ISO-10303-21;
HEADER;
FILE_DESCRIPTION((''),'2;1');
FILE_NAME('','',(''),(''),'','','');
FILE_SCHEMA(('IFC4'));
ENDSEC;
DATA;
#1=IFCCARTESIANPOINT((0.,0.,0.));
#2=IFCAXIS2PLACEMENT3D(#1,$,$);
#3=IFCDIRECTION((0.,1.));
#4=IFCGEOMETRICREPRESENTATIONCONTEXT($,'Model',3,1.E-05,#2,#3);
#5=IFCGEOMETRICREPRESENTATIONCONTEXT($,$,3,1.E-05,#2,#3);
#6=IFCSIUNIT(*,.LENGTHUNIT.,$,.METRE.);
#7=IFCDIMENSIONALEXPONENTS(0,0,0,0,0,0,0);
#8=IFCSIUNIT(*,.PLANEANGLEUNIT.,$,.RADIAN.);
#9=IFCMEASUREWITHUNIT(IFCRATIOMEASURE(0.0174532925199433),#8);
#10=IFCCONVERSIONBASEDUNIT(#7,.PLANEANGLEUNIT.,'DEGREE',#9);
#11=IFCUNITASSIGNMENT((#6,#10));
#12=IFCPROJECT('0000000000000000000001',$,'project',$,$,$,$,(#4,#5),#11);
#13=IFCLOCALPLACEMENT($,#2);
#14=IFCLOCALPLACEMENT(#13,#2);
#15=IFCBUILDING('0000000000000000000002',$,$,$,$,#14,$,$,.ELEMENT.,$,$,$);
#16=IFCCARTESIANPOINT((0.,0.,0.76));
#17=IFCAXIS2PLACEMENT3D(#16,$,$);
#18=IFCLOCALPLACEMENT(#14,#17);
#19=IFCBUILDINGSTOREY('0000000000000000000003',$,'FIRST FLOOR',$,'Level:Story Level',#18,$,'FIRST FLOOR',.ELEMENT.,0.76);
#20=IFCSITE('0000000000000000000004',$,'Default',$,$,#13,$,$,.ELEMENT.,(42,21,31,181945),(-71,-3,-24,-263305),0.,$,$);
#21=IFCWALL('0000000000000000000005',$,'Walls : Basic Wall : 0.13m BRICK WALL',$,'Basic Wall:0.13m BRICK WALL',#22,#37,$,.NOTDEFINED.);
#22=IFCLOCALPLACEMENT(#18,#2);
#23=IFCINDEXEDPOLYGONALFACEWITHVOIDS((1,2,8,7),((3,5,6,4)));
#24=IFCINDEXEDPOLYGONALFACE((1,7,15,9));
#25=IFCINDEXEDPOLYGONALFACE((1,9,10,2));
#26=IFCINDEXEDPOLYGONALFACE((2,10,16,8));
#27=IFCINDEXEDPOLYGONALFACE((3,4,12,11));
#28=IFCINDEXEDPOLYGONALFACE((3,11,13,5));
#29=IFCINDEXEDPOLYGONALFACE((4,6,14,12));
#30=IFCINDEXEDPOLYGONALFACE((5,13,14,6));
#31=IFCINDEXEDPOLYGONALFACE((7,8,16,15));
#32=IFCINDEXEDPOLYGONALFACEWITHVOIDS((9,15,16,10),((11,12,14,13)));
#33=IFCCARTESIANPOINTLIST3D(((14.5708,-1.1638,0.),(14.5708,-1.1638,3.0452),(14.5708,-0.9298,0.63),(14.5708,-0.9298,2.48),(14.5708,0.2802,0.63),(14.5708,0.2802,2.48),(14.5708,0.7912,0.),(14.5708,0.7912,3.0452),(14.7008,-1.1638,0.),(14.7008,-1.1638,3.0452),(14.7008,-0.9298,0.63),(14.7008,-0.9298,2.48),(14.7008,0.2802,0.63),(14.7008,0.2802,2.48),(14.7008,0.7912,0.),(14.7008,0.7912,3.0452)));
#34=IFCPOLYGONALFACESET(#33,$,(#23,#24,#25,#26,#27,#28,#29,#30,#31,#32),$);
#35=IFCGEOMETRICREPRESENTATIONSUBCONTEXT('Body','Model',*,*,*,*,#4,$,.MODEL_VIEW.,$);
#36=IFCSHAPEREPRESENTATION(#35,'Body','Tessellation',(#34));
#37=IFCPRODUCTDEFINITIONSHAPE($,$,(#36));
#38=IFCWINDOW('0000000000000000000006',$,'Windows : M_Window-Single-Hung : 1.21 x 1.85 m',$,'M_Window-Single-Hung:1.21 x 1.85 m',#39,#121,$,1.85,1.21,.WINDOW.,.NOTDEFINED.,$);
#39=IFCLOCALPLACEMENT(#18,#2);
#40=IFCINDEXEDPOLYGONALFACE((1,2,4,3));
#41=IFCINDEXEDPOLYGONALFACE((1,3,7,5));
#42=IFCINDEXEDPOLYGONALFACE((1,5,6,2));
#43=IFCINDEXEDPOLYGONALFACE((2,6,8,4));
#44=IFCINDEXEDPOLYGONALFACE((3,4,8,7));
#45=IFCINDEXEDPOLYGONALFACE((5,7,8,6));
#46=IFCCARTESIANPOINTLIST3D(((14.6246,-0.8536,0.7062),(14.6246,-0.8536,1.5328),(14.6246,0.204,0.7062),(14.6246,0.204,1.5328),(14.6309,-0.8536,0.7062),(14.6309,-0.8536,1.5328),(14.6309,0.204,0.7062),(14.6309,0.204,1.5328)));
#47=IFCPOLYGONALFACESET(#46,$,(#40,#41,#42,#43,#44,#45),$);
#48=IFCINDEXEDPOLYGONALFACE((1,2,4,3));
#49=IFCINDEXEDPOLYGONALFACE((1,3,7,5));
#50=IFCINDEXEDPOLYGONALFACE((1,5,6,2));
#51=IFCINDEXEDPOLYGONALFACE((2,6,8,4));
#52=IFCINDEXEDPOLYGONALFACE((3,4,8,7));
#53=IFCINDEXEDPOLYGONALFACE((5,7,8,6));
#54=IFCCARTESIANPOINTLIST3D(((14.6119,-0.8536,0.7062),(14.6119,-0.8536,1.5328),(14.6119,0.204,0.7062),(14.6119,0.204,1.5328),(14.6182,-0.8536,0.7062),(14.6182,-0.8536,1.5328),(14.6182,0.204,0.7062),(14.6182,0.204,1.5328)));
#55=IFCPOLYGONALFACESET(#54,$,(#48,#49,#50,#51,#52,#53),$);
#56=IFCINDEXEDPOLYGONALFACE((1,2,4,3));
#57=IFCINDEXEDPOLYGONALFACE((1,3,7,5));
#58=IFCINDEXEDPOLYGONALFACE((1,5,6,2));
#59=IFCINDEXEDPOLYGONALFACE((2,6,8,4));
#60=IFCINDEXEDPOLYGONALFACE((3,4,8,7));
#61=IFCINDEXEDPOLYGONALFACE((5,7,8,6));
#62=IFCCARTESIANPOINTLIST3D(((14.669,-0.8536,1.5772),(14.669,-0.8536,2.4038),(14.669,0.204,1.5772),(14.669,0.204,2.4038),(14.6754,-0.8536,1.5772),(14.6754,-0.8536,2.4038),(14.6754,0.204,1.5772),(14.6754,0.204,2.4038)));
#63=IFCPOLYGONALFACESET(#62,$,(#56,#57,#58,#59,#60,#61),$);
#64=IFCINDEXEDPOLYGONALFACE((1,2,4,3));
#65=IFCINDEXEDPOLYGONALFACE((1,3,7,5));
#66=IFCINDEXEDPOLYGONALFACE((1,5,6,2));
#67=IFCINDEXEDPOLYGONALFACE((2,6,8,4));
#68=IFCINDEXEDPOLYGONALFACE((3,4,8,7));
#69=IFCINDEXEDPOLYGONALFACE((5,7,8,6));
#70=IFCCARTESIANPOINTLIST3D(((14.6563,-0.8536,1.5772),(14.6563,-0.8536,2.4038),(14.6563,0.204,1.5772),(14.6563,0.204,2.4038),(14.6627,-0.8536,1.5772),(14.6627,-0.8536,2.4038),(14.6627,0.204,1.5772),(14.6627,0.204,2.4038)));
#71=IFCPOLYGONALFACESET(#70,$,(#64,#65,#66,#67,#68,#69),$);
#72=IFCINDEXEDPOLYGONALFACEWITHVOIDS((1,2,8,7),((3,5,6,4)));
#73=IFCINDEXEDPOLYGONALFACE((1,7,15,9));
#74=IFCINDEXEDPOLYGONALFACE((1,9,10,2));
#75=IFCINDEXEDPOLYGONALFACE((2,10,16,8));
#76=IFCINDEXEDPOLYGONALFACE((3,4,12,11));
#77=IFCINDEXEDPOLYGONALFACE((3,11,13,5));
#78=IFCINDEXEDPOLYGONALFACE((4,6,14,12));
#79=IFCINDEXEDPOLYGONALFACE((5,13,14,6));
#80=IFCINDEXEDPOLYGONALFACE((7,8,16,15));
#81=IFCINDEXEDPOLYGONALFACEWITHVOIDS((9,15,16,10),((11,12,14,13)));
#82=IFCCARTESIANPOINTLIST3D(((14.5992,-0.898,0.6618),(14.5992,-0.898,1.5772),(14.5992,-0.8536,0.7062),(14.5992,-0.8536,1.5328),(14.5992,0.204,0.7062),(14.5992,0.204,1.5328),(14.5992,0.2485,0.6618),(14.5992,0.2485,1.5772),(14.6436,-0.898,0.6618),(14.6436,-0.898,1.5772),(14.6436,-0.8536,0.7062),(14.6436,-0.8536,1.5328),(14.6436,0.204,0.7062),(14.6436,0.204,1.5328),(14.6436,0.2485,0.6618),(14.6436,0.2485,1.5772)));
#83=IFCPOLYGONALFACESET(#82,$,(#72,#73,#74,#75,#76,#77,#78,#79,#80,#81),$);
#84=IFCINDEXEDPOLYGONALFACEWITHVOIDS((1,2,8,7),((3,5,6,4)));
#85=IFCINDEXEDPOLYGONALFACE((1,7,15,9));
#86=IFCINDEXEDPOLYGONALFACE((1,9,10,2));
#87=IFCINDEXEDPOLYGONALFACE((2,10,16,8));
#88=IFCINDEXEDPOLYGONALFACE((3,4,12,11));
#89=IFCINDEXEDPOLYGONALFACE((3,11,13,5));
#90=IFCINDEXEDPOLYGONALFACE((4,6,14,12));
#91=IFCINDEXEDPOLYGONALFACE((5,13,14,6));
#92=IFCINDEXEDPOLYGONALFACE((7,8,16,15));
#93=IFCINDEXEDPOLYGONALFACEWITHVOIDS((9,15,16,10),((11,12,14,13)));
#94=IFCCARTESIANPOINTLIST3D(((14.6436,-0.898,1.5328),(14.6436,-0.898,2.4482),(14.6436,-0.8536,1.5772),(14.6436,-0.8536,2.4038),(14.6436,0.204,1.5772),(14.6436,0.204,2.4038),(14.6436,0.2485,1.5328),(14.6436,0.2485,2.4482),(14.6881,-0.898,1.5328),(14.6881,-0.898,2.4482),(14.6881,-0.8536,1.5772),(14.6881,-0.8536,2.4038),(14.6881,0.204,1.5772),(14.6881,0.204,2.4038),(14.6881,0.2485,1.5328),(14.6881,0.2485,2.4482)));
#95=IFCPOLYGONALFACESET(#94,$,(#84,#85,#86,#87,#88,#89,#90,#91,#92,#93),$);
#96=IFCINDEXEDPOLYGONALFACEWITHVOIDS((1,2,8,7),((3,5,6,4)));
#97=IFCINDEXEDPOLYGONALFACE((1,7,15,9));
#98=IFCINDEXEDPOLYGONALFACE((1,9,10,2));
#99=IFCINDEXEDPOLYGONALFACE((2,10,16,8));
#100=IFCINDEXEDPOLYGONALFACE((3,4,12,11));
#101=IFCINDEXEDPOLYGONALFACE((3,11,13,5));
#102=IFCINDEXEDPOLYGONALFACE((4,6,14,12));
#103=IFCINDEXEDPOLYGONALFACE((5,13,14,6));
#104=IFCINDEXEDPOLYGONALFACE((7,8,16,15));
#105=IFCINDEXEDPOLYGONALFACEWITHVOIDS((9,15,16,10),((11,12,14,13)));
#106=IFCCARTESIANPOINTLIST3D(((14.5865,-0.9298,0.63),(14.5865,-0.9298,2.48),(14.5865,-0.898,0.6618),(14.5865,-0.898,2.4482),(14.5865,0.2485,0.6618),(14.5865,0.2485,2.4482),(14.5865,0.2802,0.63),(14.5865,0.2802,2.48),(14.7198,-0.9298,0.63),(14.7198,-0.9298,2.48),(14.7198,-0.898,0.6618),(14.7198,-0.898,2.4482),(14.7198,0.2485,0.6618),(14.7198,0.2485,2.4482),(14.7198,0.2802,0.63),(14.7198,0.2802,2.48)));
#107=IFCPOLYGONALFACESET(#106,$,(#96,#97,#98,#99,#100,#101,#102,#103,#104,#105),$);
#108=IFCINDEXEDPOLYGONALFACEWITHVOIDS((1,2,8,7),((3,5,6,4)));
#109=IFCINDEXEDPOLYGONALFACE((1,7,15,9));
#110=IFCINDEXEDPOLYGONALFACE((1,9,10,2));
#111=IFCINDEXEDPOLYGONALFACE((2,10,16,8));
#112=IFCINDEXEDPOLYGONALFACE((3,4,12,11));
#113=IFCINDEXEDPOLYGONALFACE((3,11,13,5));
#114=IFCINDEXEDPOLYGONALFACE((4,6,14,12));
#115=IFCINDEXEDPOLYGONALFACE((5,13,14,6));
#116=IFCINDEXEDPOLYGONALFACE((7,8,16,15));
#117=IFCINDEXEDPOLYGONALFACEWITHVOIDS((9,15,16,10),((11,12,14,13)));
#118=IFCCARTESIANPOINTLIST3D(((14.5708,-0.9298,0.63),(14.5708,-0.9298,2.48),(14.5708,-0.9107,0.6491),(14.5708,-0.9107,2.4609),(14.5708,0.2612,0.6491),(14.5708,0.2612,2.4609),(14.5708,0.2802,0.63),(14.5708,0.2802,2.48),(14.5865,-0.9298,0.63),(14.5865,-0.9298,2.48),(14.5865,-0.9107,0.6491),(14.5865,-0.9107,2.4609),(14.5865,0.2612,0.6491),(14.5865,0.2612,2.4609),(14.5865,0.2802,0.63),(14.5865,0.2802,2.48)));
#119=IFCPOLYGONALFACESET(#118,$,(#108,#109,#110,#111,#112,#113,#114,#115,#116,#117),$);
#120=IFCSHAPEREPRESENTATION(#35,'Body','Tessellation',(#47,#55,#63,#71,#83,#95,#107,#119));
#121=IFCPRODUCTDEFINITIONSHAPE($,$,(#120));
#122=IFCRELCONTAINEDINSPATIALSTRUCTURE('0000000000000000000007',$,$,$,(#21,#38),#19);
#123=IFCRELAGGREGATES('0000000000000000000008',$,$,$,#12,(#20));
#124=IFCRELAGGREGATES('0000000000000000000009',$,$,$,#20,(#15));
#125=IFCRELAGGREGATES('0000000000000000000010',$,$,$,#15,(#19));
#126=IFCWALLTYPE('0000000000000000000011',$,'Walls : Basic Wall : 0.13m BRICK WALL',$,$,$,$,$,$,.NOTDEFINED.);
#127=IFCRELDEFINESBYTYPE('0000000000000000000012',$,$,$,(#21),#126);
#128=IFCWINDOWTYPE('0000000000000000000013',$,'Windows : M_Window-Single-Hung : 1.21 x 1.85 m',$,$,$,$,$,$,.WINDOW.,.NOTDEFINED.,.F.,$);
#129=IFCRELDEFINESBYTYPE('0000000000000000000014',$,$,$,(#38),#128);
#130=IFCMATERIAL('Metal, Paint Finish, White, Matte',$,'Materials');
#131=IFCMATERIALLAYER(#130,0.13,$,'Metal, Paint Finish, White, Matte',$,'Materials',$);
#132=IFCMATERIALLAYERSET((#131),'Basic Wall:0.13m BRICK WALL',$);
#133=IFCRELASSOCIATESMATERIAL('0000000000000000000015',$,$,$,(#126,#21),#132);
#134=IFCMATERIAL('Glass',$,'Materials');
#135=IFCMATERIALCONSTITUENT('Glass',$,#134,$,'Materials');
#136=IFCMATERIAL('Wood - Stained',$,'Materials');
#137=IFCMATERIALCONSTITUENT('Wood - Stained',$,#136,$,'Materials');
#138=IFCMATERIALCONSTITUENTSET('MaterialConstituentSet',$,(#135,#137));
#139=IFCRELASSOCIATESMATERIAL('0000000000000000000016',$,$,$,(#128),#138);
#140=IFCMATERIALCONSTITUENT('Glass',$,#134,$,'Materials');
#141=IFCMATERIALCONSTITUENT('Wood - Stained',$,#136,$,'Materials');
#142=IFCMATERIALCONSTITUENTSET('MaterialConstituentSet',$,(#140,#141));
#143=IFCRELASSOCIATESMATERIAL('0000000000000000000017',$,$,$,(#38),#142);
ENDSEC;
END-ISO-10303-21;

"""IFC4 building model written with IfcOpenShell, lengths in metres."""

from ifc_helpers import new_model, entity, si_unit, converted_unit, direction, frame, frame_2d, origin, origin_2d_with_axis, place, context, subcontext, project, spatial, polyline, rectangle, outline, extrude, source, transform, mapped, material, layer, layer_set, layer_usage, constituent, constituent_set, type_object, type_shapes, element, fill, save


model = new_model("IFC4")

# Units and contexts
model_context = context("Model", 3, precision=1e-05, world=origin(), true_north=direction((0.0, 1.0)))
context_of_model = context(None, 3, precision=1e-05, world=origin(), true_north=direction((0.0, 1.0)))
body_context = subcontext(model_context, "Body", "Model", "MODEL_VIEW")
ifc_project = project(units=[si_unit("LENGTHUNIT", "METRE"), converted_unit("PLANEANGLEUNIT", "DEGREE", entity("IfcRatioMeasure", 0.0174532925199433), si_unit("PLANEANGLEUNIT", "RADIAN"), dimensions=[0, 0, 0, 0, 0, 0, 0])], contexts=[model_context, context_of_model])

# Site, building, storey
site_placement = place(None, origin())
site = spatial("IfcSite", under=ifc_project, at=site_placement, Name="Default", CompositionType="ELEMENT", RefLatitude=(42, 21, 31, 181945), RefLongitude=(-71, -3, -24, -263305), RefElevation=0.0)
building_placement = place(site_placement, origin())
building = spatial("IfcBuilding", under=site, at=building_placement, CompositionType="ELEMENT")
storey_placement = place(building_placement, frame((0.0, 0.0, 0.76)))
storey = spatial("IfcBuildingStorey", under=building, at=storey_placement, Name="FIRST FLOOR", ObjectType="Level:Story Level", LongName="FIRST FLOOR", CompositionType="ELEMENT", Elevation=0.76)

# Wall, opening, window
ifc_material_1 = material(Name="Metal, Paint Finish, White, Matte", Category="Materials")
ifc_layer_1 = layer(ifc_material_1, 0.13, Name="Metal, Paint Finish, White, Matte", Category="Materials")
ifc_layer_set_1 = layer_set([ifc_layer_1], Name="Basic Wall:0.13m BRICK WALL")
ifc_layer_usage_1 = layer_usage(ifc_layer_set_1, "AXIS2", "NEGATIVE", 0.065)
wall_type_1 = type_object("IfcWallType", Name="Walls : Basic Wall : 0.13m BRICK WALL", PredefinedType="NOTDEFINED", material=ifc_layer_set_1)
wall_1_placement = place(storey_placement, frame((14.6358, 0.7912, 0.0), z_axis=(0.0, 0.0, 1.0), x_axis=(0.0, -1.0, 0.0)))
wall_1 = element("IfcWall", 1, at=wall_1_placement, inside=storey, type_object=wall_type_1, material=ifc_layer_usage_1, Name="Walls : Basic Wall : 0.13m BRICK WALL", ObjectType="Basic Wall:0.13m BRICK WALL", PredefinedType="NOTDEFINED", context=body_context, shape_type="SweptSolid", body=[
    extrude(rectangle(XDim=1.955, YDim=0.13, at=frame_2d((0.9775, 0.0), x_axis=(-1.0, 0.0))), origin(), (0.0, 0.0, 1.0), 3.0452),
])
opening_1_placement = place(wall_1_placement, frame((0.511, -0.065, 0.63)))
opening_1 = element("IfcOpeningElement", 2, at=opening_1_placement, cuts=wall_1, ObjectType="Opening", PredefinedType="OPENING", context=body_context, shape_type="SweptSolid", body=[
    extrude(rectangle(XDim=1.85, YDim=1.21, at=frame_2d((0.925, 0.605), x_axis=(-1.0, 0.0))), frame((0.0, 0.0, 0.0), z_axis=(0.0, 1.0, 0.0), x_axis=(0.0, 0.0, 1.0)), (0.0, 0.0, 1.0), 0.13),
])
ifc_material_2 = material(Name="Glass", Category="Materials")
ifc_constituent_1 = constituent(ifc_material_2, Name="Glass", Category="Materials")
ifc_material_3 = material(Name="Wood - Stained", Category="Materials")
ifc_constituent_2 = constituent(ifc_material_3, Name="Wood - Stained", Category="Materials")
ifc_constituent_set_1 = constituent_set(constituents=[ifc_constituent_1, ifc_constituent_2], Name="MaterialConstituentSet")
ifc_constituent_3 = constituent(ifc_material_2, Name="Glass", Category="Materials")
ifc_constituent_4 = constituent(ifc_material_3, Name="Wood - Stained", Category="Materials")
ifc_constituent_set_2 = constituent_set(constituents=[ifc_constituent_3, ifc_constituent_4], Name="MaterialConstituentSet")
window_type_1 = type_object("IfcWindowType", Name="Windows : M_Window-Single-Hung : 1.21 x 1.85 m", ParameterTakesPrecedence=False, PartitioningType="NOTDEFINED", PredefinedType="WINDOW", material=ifc_constituent_set_2)
shared_shape_1 = source(origin(), body_context, "Body", "SweptSolid", [
    extrude(rectangle(XDim=1.0576, YDim=0.0063, at=origin_2d_with_axis()), frame((0.605, 0.057, 0.0762), z_axis=(0.0, 0.0, 1.0), x_axis=(-1.0, 0.0, 0.0)), (0.0, 0.0, 1.0), 0.8266),
    extrude(rectangle(XDim=0.0063, YDim=1.0576, at=origin_2d_with_axis()), frame((0.605, 0.0443, 0.0762), z_axis=(0.0, 0.0, 1.0), x_axis=(0.0, -1.0, 0.0)), (0.0, 0.0, 1.0), 0.8266),
    extrude(rectangle(XDim=1.0576, YDim=0.0063, at=frame_2d((0.0, 0.0), x_axis=(1.0, 0.0))), frame((0.605, 0.1014, 0.9472), z_axis=(0.0, 0.0, 1.0), x_axis=(-1.0, 0.0, 0.0)), (0.0, 0.0, 1.0), 0.8266),
    extrude(rectangle(XDim=0.0063, YDim=1.0576, at=origin_2d_with_axis()), frame((0.605, 0.0887, 0.9472), z_axis=(0.0, 0.0, 1.0), x_axis=(0.0, -1.0, 0.0)), (0.0, 0.0, 1.0), 0.8266),
    extrude(outline(polyline([(-0.5732, -0.4577), (0.5732, -0.4577), (0.5732, 0.4577), (-0.5732, 0.4577), (-0.5732, -0.4577)]), holes=[polyline([(0.5288, -0.4133), (-0.5288, -0.4133), (-0.5288, 0.4133), (0.5288, 0.4133), (0.5288, -0.4133)])]), frame((0.605, 0.0284, 0.4895), z_axis=(0.0, 1.0, 0.0), x_axis=(1.0, 0.0, 0.0)), (0.0, 0.0, 1.0), 0.0445),
    extrude(outline(polyline([(-0.5732, -0.4577), (0.5732, -0.4577), (0.5732, 0.4577), (-0.5732, 0.4577), (-0.5732, -0.4577)]), holes=[polyline([(0.5288, -0.4133), (-0.5288, -0.4133), (-0.5288, 0.4133), (0.5288, 0.4133), (0.5288, -0.4133)])]), frame((0.605, 0.0728, 1.3605), z_axis=(0.0, 1.0, 0.0), x_axis=(1.0, 0.0, 0.0)), (0.0, 0.0, 1.0), 0.0444),
    extrude(outline(polyline([(-0.605, -0.925), (0.605, -0.925), (0.605, 0.925), (-0.605, 0.925), (-0.605, -0.925)]), holes=[polyline([(0.5732, -0.8932), (-0.5732, -0.8932), (-0.5732, 0.8932), (0.5732, 0.8932), (0.5732, -0.8932)])]), frame((0.605, 0.0157, 0.925), z_axis=(0.0, 1.0, 0.0), x_axis=(1.0, 0.0, 0.0)), (0.0, 0.0, 1.0), 0.1333),
    extrude(outline(polyline([(-0.925, -0.605), (0.925, -0.605), (0.925, 0.605), (-0.925, 0.605), (-0.925, -0.605)]), holes=[polyline([(-0.9059, -0.5859), (-0.9059, 0.5859), (0.9059, 0.5859), (0.9059, -0.5859), (-0.9059, -0.5859)])]), frame((0.605, 0.0, 0.925), z_axis=(0.0, 1.0, 0.0), x_axis=(0.0, 0.0, -1.0)), (0.0, 0.0, 1.0), 0.0157),
])
type_shapes(window_type_1, [shared_shape_1])
window_1_placement = place(opening_1_placement, origin())
window_1 = element("IfcWindow", 3, at=window_1_placement, inside=storey, type_object=window_type_1, material=ifc_constituent_set_1, Name="Windows : M_Window-Single-Hung : 1.21 x 1.85 m", ObjectType="M_Window-Single-Hung:1.21 x 1.85 m", OverallHeight=1.85, OverallWidth=1.21, PartitioningType="NOTDEFINED", PredefinedType="WINDOW", context=body_context, shape_type="MappedRepresentation", body=[
    mapped(shared_shape_1, transform((0.0, 0.0, 0.0), scale=1.0)),
])
fill(opening_1, window_1)

save(model, "model.ifc")
